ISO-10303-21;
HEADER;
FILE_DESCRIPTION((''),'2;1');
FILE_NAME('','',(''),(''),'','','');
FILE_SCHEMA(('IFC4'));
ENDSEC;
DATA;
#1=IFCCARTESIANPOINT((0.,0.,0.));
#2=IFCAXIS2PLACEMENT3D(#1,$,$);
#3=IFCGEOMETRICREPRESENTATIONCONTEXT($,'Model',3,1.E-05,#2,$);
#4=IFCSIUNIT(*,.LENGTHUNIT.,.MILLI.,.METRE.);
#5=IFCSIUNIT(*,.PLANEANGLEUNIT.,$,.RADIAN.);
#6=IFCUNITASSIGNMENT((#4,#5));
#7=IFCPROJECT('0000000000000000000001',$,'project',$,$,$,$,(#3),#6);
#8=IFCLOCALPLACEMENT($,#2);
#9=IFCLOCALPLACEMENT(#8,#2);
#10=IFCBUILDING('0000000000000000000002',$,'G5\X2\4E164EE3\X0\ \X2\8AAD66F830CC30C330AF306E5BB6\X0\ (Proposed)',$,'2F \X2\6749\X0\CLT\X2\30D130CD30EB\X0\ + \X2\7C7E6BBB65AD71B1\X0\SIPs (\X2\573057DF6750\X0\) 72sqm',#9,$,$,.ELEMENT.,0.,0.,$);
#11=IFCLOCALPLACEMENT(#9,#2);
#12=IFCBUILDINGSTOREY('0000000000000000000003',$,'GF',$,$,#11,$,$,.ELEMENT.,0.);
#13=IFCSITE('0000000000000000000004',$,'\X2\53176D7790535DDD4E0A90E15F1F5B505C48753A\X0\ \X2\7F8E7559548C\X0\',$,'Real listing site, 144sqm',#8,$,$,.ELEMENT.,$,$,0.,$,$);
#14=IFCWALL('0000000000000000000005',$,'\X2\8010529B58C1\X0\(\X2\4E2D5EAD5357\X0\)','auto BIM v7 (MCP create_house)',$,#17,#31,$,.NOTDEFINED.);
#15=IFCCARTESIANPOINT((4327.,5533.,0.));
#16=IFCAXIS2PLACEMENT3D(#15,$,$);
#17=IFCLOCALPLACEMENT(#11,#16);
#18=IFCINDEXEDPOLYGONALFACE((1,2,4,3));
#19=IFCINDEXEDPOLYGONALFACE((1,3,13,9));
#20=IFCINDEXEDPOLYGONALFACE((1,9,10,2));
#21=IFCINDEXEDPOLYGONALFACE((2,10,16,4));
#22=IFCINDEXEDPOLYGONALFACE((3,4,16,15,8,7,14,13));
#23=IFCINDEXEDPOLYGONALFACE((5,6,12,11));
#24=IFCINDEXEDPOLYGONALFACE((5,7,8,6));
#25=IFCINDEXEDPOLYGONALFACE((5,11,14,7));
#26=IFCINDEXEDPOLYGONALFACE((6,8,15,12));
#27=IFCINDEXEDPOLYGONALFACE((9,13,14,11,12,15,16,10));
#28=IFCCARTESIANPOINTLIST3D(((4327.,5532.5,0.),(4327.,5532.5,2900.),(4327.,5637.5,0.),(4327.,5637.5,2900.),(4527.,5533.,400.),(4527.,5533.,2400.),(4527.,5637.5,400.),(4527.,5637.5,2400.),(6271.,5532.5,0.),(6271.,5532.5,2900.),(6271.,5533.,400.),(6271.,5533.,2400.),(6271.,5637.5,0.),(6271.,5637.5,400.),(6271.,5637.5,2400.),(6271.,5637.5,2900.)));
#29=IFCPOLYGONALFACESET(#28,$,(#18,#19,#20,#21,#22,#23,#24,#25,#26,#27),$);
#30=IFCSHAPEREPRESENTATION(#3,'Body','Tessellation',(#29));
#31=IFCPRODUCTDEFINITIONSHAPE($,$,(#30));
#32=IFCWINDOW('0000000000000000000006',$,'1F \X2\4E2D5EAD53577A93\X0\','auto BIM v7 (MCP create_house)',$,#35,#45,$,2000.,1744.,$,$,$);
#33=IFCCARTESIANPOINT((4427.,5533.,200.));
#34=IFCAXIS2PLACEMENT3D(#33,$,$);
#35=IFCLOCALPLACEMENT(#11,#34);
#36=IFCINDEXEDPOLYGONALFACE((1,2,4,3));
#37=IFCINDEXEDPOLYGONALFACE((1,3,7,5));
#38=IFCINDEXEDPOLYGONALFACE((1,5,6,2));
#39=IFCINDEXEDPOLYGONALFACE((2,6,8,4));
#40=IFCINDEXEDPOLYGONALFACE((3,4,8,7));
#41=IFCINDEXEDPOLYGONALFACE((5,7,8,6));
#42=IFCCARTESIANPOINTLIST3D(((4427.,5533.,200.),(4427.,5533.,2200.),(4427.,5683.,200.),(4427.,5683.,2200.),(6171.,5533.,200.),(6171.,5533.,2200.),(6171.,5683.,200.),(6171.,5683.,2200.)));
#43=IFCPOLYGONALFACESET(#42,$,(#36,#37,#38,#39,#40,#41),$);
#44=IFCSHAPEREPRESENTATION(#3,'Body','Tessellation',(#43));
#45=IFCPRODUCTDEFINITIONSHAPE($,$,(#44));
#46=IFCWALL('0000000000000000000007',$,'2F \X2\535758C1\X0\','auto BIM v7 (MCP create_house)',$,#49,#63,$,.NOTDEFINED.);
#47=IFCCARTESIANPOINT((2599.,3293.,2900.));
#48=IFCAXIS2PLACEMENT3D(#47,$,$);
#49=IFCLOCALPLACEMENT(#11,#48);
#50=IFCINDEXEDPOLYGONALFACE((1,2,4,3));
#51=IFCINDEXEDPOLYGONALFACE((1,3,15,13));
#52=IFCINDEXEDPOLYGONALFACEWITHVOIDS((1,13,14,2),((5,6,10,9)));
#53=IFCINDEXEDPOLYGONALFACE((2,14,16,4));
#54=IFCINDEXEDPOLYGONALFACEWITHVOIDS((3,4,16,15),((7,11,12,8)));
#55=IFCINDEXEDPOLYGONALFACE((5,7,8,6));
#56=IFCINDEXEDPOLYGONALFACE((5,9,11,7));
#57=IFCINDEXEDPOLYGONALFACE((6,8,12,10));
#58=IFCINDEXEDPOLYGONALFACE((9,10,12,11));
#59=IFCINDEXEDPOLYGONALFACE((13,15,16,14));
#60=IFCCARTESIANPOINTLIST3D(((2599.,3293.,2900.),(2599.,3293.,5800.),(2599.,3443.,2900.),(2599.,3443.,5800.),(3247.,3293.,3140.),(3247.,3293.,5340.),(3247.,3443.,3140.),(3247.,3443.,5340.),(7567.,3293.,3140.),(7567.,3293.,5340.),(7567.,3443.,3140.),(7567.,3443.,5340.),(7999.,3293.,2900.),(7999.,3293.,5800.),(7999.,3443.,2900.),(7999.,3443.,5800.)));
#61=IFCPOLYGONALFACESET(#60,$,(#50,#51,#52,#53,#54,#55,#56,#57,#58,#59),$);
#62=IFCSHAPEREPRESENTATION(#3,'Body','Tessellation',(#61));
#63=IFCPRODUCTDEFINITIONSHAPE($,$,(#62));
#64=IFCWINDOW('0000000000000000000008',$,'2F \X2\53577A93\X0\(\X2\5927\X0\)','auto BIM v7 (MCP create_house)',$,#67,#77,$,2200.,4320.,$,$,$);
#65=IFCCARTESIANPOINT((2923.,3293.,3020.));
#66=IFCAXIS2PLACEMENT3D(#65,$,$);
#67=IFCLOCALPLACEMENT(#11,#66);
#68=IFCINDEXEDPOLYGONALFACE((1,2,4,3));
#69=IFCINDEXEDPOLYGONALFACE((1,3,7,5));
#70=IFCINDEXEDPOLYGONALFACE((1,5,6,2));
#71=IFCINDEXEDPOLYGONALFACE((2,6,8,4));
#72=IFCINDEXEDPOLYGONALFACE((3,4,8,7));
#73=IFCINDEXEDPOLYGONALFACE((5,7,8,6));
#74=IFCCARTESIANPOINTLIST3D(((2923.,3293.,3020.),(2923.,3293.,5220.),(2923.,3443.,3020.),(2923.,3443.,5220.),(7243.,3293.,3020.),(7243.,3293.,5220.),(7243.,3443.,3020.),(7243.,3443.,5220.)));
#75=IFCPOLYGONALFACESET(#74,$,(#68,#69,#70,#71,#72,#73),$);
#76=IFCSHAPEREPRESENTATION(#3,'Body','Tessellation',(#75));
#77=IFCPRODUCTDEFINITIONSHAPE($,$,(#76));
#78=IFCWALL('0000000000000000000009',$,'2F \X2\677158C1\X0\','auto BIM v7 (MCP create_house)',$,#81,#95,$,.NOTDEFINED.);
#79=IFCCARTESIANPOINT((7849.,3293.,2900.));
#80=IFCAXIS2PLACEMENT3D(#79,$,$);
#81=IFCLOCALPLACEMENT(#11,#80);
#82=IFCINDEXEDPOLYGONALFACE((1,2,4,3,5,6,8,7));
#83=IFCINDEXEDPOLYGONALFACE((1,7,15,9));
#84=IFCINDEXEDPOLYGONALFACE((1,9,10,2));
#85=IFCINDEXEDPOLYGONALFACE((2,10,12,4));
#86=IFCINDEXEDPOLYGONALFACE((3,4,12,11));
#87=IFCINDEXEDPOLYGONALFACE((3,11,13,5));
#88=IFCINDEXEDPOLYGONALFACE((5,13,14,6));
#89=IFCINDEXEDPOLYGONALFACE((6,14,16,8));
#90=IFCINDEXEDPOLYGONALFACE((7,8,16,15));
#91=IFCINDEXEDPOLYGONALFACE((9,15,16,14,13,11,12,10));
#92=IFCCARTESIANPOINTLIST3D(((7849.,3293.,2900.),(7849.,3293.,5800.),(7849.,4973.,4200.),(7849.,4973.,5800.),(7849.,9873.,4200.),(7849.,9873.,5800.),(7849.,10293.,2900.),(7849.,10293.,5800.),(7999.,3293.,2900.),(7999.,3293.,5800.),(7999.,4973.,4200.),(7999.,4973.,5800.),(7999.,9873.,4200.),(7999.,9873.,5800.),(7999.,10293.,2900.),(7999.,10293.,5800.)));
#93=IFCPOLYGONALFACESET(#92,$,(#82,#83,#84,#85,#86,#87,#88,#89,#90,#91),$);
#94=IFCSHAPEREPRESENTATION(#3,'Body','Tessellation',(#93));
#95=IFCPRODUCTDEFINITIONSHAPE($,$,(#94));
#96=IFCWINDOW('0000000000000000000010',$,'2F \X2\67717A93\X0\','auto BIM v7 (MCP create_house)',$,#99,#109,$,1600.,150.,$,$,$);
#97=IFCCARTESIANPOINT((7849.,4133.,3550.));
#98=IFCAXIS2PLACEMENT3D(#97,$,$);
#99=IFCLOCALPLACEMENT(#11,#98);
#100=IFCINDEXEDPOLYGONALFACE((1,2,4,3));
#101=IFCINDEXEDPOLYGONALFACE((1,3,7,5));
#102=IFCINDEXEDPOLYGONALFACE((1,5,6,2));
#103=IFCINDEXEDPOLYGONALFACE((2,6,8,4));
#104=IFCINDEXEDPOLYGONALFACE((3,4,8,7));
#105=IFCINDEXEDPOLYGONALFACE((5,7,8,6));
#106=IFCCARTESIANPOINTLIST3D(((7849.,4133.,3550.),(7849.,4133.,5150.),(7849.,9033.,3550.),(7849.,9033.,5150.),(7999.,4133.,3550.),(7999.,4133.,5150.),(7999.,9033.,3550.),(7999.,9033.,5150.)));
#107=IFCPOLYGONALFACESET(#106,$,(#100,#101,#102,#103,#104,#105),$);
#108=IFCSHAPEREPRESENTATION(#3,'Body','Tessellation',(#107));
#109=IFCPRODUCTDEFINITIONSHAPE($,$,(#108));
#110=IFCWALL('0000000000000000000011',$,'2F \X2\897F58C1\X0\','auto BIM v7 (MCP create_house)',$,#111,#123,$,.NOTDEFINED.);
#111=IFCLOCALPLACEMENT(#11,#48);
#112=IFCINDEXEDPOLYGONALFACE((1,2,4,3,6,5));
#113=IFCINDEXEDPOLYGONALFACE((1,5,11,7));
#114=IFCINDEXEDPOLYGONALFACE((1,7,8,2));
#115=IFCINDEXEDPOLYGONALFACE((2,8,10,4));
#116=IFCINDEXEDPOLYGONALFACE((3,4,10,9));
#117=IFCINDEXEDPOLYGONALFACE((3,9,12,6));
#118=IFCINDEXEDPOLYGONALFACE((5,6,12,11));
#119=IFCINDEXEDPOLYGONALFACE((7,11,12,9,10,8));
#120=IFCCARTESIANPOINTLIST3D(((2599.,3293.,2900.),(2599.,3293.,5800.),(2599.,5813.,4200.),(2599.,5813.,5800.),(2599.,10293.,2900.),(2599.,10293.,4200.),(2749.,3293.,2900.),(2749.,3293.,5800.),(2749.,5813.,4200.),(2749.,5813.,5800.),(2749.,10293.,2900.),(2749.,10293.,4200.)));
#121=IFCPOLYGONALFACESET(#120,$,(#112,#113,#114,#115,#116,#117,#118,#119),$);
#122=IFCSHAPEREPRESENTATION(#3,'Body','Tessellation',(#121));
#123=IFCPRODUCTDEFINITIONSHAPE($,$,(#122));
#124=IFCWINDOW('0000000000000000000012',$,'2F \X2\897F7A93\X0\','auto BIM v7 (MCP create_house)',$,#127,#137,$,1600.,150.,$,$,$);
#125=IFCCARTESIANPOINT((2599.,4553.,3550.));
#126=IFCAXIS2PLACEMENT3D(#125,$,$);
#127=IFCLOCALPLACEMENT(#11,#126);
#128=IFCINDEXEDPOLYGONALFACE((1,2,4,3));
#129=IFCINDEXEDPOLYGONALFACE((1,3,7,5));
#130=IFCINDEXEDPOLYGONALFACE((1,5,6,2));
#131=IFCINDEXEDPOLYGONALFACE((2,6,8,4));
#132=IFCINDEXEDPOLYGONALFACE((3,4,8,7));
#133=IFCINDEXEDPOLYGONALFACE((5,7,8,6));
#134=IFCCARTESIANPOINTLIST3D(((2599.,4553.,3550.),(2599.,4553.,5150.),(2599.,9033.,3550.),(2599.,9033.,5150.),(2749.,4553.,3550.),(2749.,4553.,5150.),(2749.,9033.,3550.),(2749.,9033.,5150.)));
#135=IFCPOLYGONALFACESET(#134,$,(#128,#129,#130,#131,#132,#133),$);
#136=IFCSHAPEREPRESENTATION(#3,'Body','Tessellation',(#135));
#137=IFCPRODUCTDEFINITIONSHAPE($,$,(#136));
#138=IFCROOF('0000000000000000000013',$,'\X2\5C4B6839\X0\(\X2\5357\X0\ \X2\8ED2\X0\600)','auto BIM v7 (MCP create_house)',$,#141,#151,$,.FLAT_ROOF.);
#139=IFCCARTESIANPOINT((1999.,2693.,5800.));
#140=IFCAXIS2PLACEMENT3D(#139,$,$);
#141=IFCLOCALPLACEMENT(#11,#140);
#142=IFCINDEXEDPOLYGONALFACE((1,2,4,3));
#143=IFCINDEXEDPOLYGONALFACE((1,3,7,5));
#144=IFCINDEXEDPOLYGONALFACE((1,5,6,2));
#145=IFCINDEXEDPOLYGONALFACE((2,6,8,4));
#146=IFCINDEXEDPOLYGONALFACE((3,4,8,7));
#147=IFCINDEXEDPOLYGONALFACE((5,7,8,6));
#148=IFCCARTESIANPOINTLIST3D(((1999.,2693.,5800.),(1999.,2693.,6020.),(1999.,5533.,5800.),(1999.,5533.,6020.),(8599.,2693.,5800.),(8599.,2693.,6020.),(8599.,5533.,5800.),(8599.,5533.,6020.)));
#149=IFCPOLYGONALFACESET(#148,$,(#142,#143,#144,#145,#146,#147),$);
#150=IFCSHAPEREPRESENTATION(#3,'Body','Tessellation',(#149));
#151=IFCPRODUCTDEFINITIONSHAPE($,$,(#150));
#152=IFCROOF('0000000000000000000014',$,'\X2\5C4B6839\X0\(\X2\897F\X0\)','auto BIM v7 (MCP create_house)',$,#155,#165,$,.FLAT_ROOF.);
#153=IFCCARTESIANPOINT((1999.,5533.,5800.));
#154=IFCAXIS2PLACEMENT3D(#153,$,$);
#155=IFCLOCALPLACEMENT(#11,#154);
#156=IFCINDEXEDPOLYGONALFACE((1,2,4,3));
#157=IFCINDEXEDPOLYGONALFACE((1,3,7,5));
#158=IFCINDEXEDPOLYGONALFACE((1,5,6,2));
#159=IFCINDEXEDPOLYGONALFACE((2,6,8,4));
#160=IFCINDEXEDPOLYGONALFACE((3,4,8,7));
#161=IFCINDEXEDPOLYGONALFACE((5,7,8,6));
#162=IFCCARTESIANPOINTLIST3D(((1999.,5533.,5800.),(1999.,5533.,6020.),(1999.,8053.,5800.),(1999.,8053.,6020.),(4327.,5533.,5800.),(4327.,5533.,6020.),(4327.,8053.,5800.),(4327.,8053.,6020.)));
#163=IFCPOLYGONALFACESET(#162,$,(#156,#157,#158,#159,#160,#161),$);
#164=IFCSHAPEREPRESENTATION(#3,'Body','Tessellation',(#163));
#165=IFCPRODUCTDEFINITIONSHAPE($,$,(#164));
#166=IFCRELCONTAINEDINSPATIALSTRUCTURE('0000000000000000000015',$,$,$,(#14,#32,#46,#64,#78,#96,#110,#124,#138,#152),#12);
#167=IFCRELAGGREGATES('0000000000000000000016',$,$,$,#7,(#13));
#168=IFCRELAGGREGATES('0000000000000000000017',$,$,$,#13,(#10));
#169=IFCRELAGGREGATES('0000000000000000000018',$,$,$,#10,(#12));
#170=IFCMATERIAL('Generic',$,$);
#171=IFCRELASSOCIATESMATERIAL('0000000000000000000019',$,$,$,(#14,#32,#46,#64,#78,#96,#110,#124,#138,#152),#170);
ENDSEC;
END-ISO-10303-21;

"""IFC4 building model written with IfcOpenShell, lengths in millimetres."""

from ifc_helpers import new_model, si_unit, frame, frame_2d, origin, place, context, project, spatial, rectangle, extrude, material, element, fill, save


model = new_model("IFC4")

# Units and contexts
model_context = context("Model", 3, precision=1e-05, world=origin())
ifc_project = project(units=[si_unit("LENGTHUNIT", "METRE", prefix="MILLI"), si_unit("PLANEANGLEUNIT", "RADIAN")], contexts=[model_context])

# Site, building, storey
site_placement = place(None, origin())
site = spatial("IfcSite", under=ifc_project, at=site_placement, Name="北海道川上郡弟子屈町 美留和", ObjectType="Real listing site, 144sqm", CompositionType="ELEMENT", RefElevation=0.0)
building_placement = place(site_placement, origin())
building = spatial("IfcBuilding", under=site, at=building_placement, Name="G5世代 読書ヌックの家 (Proposed)", ObjectType="2F 杉CLTパネル + 籾殻断熱SIPs (地域材) 72sqm", CompositionType="ELEMENT", ElevationOfRefHeight=0.0, ElevationOfTerrain=0.0)
storey_placement = place(building_placement, origin())
storey = spatial("IfcBuildingStorey", under=building, at=storey_placement, Name="GF", CompositionType="ELEMENT", Elevation=0.0)

# Shared definitions
ifc_material = material(Name="Generic")

# Wall, opening, window
wall_1_placement = place(storey_placement, frame((4327.0, 5533.0, 0.0)))
wall_1 = element("IfcWall", 1, at=wall_1_placement, inside=storey, material=ifc_material, Name="耐力壁(中庭南)", Description="auto BIM v7 (MCP create_house)", PredefinedType="NOTDEFINED", context=model_context, shape_type="SweptSolid", body=[
    extrude(rectangle(XDim=1944.0, YDim=105.0, at=frame_2d((972.0, 52.0))), frame((4327.0, 5533.0, 0.0)), (0.0, 0.0, 1.0), 2900.0),
])
opening_1_placement = place(storey_placement, frame((4427.0, 5533.0, 200.0)))
opening_1 = element("IfcOpeningElement", 2, at=opening_1_placement, cuts=wall_1, PredefinedType="NOTDEFINED", context=model_context, shape_type="SweptSolid", body=[
    extrude(rectangle(XDim=1744.0, YDim=150.0, at=frame_2d((872.0, 75.0))), frame((4427.0, 5533.0, 200.0)), (0.0, 0.0, 1.0), 2000.0),
])
window_1_placement = place(storey_placement, frame((4427.0, 5533.0, 200.0)))
window_1 = element("IfcWindow", 3, at=window_1_placement, inside=storey, material=ifc_material, Name="1F 中庭南窓", Description="auto BIM v7 (MCP create_house)", OverallHeight=2000.0, OverallWidth=1744.0, context=model_context, shape_type="SweptSolid", body=[
    extrude(rectangle(XDim=1744.0, YDim=150.0, at=frame_2d((872.0, 75.0))), frame((4427.0, 5533.0, 200.0)), (0.0, 0.0, 1.0), 2000.0),
])
fill(opening_1, window_1)

# Walls, openings, windows
wall_2_placement = place(storey_placement, frame((2599.0, 3293.0, 2900.0)))
wall_2 = element("IfcWall", 4, at=wall_2_placement, inside=storey, material=ifc_material, Name="2F 南壁", Description="auto BIM v7 (MCP create_house)", PredefinedType="NOTDEFINED", context=model_context, shape_type="SweptSolid", body=[
    extrude(rectangle(XDim=5400.0, YDim=150.0, at=frame_2d((2700.0, 75.0))), frame((2599.0, 3293.0, 2900.0)), (0.0, 0.0, 1.0), 2900.0),
])
opening_2_placement = place(storey_placement, frame((2923.0, 3293.0, 3020.0)))
opening_2 = element("IfcOpeningElement", 5, at=opening_2_placement, cuts=wall_2, PredefinedType="NOTDEFINED", context=model_context, shape_type="SweptSolid", body=[
    extrude(rectangle(XDim=4320.0, YDim=150.0, at=frame_2d((2160.0, 75.0))), frame((2923.0, 3293.0, 3020.0)), (0.0, 0.0, 1.0), 2200.0),
])
window_2_placement = place(storey_placement, frame((2923.0, 3293.0, 3020.0)))
window_2 = element("IfcWindow", 6, at=window_2_placement, inside=storey, material=ifc_material, Name="2F 南窓(大)", Description="auto BIM v7 (MCP create_house)", OverallHeight=2200.0, OverallWidth=4320.0, context=model_context, shape_type="SweptSolid", body=[
    extrude(rectangle(XDim=4320.0, YDim=150.0, at=frame_2d((2160.0, 75.0))), frame((2923.0, 3293.0, 3020.0)), (0.0, 0.0, 1.0), 2200.0),
])
fill(opening_2, window_2)
wall_3_placement = place(storey_placement, frame((7849.0, 3293.0, 2900.0)))
wall_3 = element("IfcWall", 7, at=wall_3_placement, inside=storey, material=ifc_material, Name="2F 東壁", Description="auto BIM v7 (MCP create_house)", PredefinedType="NOTDEFINED", context=model_context, shape_type="SweptSolid", body=[
    extrude(rectangle(XDim=150.0, YDim=7000.0, at=frame_2d((75.0, 3500.0))), frame((7849.0, 3293.0, 2900.0)), (0.0, 0.0, 1.0), 2900.0),
])
opening_3_placement = place(storey_placement, frame((7849.0, 4133.0, 3550.0)))
opening_3 = element("IfcOpeningElement", 8, at=opening_3_placement, cuts=wall_3, PredefinedType="NOTDEFINED", context=model_context, shape_type="SweptSolid", body=[
    extrude(rectangle(XDim=150.0, YDim=4900.0, at=frame_2d((75.0, 2450.0))), frame((7849.0, 4133.0, 3550.0)), (0.0, 0.0, 1.0), 1600.0),
])
window_3_placement = place(storey_placement, frame((7849.0, 4133.0, 3550.0)))
window_3 = element("IfcWindow", 9, at=window_3_placement, inside=storey, material=ifc_material, Name="2F 東窓", Description="auto BIM v7 (MCP create_house)", OverallHeight=1600.0, OverallWidth=150.0, context=model_context, shape_type="SweptSolid", body=[
    extrude(rectangle(XDim=150.0, YDim=4900.0, at=frame_2d((75.0, 2450.0))), frame((7849.0, 4133.0, 3550.0)), (0.0, 0.0, 1.0), 1600.0),
])
fill(opening_3, window_3)
wall_4_placement = place(storey_placement, frame((2599.0, 3293.0, 2900.0)))
wall_4 = element("IfcWall", 10, at=wall_4_placement, inside=storey, material=ifc_material, Name="2F 西壁", Description="auto BIM v7 (MCP create_house)", PredefinedType="NOTDEFINED", context=model_context, shape_type="SweptSolid", body=[
    extrude(rectangle(XDim=150.0, YDim=7000.0, at=frame_2d((75.0, 3500.0))), frame((2599.0, 3293.0, 2900.0)), (0.0, 0.0, 1.0), 2900.0),
])
opening_4_placement = place(storey_placement, frame((2599.0, 4553.0, 3550.0)))
opening_4 = element("IfcOpeningElement", 11, at=opening_4_placement, cuts=wall_4, PredefinedType="NOTDEFINED", context=model_context, shape_type="SweptSolid", body=[
    extrude(rectangle(XDim=150.0, YDim=4480.0, at=frame_2d((75.0, 2240.0))), frame((2599.0, 4553.0, 3550.0)), (0.0, 0.0, 1.0), 1600.0),
])
window_4_placement = place(storey_placement, frame((2599.0, 4553.0, 3550.0)))
window_4 = element("IfcWindow", 12, at=window_4_placement, inside=storey, material=ifc_material, Name="2F 西窓", Description="auto BIM v7 (MCP create_house)", OverallHeight=1600.0, OverallWidth=150.0, context=model_context, shape_type="SweptSolid", body=[
    extrude(rectangle(XDim=150.0, YDim=4480.0, at=frame_2d((75.0, 2240.0))), frame((2599.0, 4553.0, 3550.0)), (0.0, 0.0, 1.0), 1600.0),
])
fill(opening_4, window_4)

# Roofs
roof_1_placement = place(storey_placement, frame((1999.0, 2693.0, 5800.0)))
element("IfcRoof", 13, at=roof_1_placement, inside=storey, material=ifc_material, Name="屋根(南 軒600)", Description="auto BIM v7 (MCP create_house)", PredefinedType="FLAT_ROOF", context=model_context, shape_type="SweptSolid", body=[
    extrude(rectangle(XDim=6600.0, YDim=2840.0, at=frame_2d((3300.0, 1420.0))), frame((1999.0, 2693.0, 5800.0)), (0.0, 0.0, 1.0), 220.0),
])
roof_2_placement = place(storey_placement, frame((1999.0, 5533.0, 5800.0)))
element("IfcRoof", 14, at=roof_2_placement, inside=storey, material=ifc_material, Name="屋根(西)", Description="auto BIM v7 (MCP create_house)", PredefinedType="FLAT_ROOF", context=model_context, shape_type="SweptSolid", body=[
    extrude(rectangle(XDim=2328.0, YDim=2520.0, at=frame_2d((1164.0, 1260.0))), frame((1999.0, 5533.0, 5800.0)), (0.0, 0.0, 1.0), 220.0),
])

save(model, "model.ifc")
